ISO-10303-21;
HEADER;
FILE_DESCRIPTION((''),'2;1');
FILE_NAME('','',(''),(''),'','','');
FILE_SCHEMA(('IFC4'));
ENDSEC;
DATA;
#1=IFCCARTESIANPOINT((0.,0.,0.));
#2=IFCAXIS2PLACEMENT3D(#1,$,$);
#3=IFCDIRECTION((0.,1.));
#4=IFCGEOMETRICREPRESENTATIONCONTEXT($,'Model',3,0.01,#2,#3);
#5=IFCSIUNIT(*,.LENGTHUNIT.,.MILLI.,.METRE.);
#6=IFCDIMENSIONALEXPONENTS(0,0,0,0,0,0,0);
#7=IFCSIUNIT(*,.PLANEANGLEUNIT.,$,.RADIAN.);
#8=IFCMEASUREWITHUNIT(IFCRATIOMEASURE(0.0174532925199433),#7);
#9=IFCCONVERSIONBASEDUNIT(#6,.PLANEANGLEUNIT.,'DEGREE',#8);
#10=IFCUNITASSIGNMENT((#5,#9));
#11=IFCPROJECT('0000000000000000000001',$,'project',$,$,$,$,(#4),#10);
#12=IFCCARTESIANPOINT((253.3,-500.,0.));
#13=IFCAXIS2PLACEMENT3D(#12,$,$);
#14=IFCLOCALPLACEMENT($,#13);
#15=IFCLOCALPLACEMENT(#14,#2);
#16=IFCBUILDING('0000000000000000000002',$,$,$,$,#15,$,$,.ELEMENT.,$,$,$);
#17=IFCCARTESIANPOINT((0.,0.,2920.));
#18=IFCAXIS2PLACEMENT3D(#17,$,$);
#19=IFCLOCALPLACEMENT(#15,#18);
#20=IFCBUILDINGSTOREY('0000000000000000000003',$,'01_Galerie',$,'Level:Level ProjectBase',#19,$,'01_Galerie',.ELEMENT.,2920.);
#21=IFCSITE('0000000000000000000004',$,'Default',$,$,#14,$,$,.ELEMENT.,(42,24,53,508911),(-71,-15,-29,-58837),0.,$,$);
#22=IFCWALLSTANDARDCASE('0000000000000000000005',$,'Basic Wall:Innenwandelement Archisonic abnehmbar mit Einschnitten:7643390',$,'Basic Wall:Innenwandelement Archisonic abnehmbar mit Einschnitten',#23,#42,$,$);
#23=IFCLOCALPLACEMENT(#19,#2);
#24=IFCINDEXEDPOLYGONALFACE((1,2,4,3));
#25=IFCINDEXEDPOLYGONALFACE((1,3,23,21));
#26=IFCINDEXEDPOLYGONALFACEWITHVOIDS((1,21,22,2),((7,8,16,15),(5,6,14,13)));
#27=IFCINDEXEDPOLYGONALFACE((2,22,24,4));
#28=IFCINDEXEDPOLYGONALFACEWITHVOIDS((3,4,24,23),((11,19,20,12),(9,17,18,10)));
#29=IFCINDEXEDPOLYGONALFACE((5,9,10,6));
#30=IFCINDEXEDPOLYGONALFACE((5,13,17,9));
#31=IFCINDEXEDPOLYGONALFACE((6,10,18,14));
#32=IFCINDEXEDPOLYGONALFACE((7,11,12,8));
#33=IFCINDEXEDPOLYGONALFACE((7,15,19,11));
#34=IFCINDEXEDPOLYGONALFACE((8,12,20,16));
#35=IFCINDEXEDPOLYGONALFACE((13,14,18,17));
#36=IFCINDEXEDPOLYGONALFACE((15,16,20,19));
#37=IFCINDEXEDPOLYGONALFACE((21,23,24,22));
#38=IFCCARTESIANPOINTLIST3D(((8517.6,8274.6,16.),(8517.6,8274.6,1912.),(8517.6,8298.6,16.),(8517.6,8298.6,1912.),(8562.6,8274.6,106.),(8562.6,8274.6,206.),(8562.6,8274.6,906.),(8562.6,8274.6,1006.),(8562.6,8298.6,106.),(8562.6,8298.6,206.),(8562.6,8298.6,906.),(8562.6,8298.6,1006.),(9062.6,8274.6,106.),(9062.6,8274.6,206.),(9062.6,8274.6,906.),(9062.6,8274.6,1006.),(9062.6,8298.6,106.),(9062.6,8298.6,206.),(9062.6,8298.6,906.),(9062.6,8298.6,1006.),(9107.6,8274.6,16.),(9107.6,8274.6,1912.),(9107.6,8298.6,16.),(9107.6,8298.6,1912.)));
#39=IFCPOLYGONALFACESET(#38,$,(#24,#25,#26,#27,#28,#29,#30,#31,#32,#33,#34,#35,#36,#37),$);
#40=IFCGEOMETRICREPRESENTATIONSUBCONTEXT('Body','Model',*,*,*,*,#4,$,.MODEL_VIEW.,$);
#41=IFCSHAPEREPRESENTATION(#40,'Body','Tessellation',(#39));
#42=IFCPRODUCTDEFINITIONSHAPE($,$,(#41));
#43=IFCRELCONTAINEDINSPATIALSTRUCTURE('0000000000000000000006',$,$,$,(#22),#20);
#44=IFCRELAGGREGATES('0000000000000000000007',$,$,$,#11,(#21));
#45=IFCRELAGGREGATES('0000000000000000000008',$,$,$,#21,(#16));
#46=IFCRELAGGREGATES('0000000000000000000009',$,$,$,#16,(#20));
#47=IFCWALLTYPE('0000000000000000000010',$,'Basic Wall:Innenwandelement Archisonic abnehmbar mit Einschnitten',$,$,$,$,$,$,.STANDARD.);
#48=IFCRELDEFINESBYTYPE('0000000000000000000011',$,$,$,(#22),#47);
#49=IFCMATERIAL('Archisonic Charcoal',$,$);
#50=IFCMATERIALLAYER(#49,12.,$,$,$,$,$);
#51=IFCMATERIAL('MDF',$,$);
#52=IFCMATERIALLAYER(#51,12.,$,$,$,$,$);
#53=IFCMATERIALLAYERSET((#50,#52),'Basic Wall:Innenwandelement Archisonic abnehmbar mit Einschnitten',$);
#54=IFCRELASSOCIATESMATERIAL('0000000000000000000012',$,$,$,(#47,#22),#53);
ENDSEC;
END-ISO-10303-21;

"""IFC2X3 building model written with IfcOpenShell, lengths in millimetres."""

from ifc_helpers import new_model, entity, si_unit, converted_unit, direction, frame, frame_2d, origin, place, context, subcontext, project, spatial, rectangle, extrude, material, layer, layer_set, layer_usage, type_object, element, save


model = new_model("IFC2X3")

# Units and contexts
model_context = context("Model", 3, precision=0.01, world=origin(), true_north=direction((0.0, 1.0)))
body_context = subcontext(model_context, "Body", "Model", "MODEL_VIEW")
ifc_project = project(units=[si_unit("LENGTHUNIT", "METRE", prefix="MILLI"), converted_unit("PLANEANGLEUNIT", "DEGREE", entity("IfcRatioMeasure", 0.0174532925199433), si_unit("PLANEANGLEUNIT", "RADIAN"), dimensions=[0, 0, 0, 0, 0, 0, 0])], contexts=[model_context])

# Site, building, storey
site_placement = place(None, frame((253.3, -500.0, 0.0)))
site = spatial("IfcSite", under=ifc_project, at=site_placement, Name="Default", CompositionType="ELEMENT", RefLatitude=(42, 24, 53, 508911), RefLongitude=(-71, -15, -29, -58837), RefElevation=0.0)
building_placement = place(site_placement, origin())
building = spatial("IfcBuilding", under=site, at=building_placement, CompositionType="ELEMENT")
storey_placement = place(building_placement, frame((0.0, 0.0, 2920.0)))
storey = spatial("IfcBuildingStorey", under=building, at=storey_placement, Name="01_Galerie", ObjectType="Level:Level ProjectBase", LongName="01_Galerie", CompositionType="ELEMENT", Elevation=2920.0)

# Shared definitions
ifc_material_1 = material(Name="Archisonic Charcoal")
ifc_material_2 = material(Name="MDF")

# Wall, openings
ifc_layer_1 = layer(ifc_material_1, 12.0)
ifc_layer_2 = layer(ifc_material_2, 12.0)
ifc_layer_set_1 = layer_set([ifc_layer_1, ifc_layer_2], Name="Basic Wall:Innenwandelement Archisonic abnehmbar mit Einschnitten")
ifc_layer_usage_1 = layer_usage(ifc_layer_set_1, "AXIS2", "NEGATIVE", 12.0)
wall_type_1 = type_object("IfcWallType", Name="Basic Wall:Innenwandelement Archisonic abnehmbar mit Einschnitten", PredefinedType="STANDARD", material=ifc_layer_set_1)
wall_1_placement = place(storey_placement, frame((9107.6, 8286.6, 16.0), z_axis=(0.0, 0.0, 1.0), x_axis=(-1.0, 0.0, 0.0)))
wall_1 = element("IfcWallStandardCase", 1, at=wall_1_placement, inside=storey, type_object=wall_type_1, material=ifc_layer_usage_1, Name="Basic Wall:Innenwandelement Archisonic abnehmbar mit Einschnitten:7643390", ObjectType="Basic Wall:Innenwandelement Archisonic abnehmbar mit Einschnitten", context=body_context, shape_type="SweptSolid", body=[
    extrude(rectangle(XDim=590.0, YDim=24.0, at=frame_2d((295.0, 0.0), x_axis=(-1.0, 0.0))), origin(), (0.0, 0.0, 1.0), 1896.0),
])
opening_1_placement = place(wall_1_placement, frame((545.0, 61.6, 890.0)))
element("IfcOpeningElement", 2, at=opening_1_placement, cuts=wall_1, ObjectType="Opening", context=body_context, shape_type="SweptSolid", body=[
    extrude(rectangle(XDim=100.0, YDim=500.0, at=frame_2d((0.0, 0.0), x_axis=(1.0, 0.0))), frame((-250.0, -422.6, 50.0), z_axis=(0.0, 1.0, 0.0), x_axis=(0.0, 0.0, 1.0)), (0.0, 0.0, 1.0), 422.6),
])
opening_2_placement = place(wall_1_placement, frame((545.0, 61.6, 90.0)))
element("IfcOpeningElement", 3, at=opening_2_placement, cuts=wall_1, ObjectType="Opening", context=body_context, shape_type="SweptSolid", body=[
    extrude(rectangle(XDim=100.0, YDim=500.0, at=frame_2d((0.0, 0.0), x_axis=(1.0, 0.0))), frame((-250.0, -280.4, 50.0), z_axis=(0.0, 1.0, 0.0), x_axis=(0.0, 0.0, 1.0)), (0.0, 0.0, 1.0), 280.4),
])

save(model, "model.ifc")
